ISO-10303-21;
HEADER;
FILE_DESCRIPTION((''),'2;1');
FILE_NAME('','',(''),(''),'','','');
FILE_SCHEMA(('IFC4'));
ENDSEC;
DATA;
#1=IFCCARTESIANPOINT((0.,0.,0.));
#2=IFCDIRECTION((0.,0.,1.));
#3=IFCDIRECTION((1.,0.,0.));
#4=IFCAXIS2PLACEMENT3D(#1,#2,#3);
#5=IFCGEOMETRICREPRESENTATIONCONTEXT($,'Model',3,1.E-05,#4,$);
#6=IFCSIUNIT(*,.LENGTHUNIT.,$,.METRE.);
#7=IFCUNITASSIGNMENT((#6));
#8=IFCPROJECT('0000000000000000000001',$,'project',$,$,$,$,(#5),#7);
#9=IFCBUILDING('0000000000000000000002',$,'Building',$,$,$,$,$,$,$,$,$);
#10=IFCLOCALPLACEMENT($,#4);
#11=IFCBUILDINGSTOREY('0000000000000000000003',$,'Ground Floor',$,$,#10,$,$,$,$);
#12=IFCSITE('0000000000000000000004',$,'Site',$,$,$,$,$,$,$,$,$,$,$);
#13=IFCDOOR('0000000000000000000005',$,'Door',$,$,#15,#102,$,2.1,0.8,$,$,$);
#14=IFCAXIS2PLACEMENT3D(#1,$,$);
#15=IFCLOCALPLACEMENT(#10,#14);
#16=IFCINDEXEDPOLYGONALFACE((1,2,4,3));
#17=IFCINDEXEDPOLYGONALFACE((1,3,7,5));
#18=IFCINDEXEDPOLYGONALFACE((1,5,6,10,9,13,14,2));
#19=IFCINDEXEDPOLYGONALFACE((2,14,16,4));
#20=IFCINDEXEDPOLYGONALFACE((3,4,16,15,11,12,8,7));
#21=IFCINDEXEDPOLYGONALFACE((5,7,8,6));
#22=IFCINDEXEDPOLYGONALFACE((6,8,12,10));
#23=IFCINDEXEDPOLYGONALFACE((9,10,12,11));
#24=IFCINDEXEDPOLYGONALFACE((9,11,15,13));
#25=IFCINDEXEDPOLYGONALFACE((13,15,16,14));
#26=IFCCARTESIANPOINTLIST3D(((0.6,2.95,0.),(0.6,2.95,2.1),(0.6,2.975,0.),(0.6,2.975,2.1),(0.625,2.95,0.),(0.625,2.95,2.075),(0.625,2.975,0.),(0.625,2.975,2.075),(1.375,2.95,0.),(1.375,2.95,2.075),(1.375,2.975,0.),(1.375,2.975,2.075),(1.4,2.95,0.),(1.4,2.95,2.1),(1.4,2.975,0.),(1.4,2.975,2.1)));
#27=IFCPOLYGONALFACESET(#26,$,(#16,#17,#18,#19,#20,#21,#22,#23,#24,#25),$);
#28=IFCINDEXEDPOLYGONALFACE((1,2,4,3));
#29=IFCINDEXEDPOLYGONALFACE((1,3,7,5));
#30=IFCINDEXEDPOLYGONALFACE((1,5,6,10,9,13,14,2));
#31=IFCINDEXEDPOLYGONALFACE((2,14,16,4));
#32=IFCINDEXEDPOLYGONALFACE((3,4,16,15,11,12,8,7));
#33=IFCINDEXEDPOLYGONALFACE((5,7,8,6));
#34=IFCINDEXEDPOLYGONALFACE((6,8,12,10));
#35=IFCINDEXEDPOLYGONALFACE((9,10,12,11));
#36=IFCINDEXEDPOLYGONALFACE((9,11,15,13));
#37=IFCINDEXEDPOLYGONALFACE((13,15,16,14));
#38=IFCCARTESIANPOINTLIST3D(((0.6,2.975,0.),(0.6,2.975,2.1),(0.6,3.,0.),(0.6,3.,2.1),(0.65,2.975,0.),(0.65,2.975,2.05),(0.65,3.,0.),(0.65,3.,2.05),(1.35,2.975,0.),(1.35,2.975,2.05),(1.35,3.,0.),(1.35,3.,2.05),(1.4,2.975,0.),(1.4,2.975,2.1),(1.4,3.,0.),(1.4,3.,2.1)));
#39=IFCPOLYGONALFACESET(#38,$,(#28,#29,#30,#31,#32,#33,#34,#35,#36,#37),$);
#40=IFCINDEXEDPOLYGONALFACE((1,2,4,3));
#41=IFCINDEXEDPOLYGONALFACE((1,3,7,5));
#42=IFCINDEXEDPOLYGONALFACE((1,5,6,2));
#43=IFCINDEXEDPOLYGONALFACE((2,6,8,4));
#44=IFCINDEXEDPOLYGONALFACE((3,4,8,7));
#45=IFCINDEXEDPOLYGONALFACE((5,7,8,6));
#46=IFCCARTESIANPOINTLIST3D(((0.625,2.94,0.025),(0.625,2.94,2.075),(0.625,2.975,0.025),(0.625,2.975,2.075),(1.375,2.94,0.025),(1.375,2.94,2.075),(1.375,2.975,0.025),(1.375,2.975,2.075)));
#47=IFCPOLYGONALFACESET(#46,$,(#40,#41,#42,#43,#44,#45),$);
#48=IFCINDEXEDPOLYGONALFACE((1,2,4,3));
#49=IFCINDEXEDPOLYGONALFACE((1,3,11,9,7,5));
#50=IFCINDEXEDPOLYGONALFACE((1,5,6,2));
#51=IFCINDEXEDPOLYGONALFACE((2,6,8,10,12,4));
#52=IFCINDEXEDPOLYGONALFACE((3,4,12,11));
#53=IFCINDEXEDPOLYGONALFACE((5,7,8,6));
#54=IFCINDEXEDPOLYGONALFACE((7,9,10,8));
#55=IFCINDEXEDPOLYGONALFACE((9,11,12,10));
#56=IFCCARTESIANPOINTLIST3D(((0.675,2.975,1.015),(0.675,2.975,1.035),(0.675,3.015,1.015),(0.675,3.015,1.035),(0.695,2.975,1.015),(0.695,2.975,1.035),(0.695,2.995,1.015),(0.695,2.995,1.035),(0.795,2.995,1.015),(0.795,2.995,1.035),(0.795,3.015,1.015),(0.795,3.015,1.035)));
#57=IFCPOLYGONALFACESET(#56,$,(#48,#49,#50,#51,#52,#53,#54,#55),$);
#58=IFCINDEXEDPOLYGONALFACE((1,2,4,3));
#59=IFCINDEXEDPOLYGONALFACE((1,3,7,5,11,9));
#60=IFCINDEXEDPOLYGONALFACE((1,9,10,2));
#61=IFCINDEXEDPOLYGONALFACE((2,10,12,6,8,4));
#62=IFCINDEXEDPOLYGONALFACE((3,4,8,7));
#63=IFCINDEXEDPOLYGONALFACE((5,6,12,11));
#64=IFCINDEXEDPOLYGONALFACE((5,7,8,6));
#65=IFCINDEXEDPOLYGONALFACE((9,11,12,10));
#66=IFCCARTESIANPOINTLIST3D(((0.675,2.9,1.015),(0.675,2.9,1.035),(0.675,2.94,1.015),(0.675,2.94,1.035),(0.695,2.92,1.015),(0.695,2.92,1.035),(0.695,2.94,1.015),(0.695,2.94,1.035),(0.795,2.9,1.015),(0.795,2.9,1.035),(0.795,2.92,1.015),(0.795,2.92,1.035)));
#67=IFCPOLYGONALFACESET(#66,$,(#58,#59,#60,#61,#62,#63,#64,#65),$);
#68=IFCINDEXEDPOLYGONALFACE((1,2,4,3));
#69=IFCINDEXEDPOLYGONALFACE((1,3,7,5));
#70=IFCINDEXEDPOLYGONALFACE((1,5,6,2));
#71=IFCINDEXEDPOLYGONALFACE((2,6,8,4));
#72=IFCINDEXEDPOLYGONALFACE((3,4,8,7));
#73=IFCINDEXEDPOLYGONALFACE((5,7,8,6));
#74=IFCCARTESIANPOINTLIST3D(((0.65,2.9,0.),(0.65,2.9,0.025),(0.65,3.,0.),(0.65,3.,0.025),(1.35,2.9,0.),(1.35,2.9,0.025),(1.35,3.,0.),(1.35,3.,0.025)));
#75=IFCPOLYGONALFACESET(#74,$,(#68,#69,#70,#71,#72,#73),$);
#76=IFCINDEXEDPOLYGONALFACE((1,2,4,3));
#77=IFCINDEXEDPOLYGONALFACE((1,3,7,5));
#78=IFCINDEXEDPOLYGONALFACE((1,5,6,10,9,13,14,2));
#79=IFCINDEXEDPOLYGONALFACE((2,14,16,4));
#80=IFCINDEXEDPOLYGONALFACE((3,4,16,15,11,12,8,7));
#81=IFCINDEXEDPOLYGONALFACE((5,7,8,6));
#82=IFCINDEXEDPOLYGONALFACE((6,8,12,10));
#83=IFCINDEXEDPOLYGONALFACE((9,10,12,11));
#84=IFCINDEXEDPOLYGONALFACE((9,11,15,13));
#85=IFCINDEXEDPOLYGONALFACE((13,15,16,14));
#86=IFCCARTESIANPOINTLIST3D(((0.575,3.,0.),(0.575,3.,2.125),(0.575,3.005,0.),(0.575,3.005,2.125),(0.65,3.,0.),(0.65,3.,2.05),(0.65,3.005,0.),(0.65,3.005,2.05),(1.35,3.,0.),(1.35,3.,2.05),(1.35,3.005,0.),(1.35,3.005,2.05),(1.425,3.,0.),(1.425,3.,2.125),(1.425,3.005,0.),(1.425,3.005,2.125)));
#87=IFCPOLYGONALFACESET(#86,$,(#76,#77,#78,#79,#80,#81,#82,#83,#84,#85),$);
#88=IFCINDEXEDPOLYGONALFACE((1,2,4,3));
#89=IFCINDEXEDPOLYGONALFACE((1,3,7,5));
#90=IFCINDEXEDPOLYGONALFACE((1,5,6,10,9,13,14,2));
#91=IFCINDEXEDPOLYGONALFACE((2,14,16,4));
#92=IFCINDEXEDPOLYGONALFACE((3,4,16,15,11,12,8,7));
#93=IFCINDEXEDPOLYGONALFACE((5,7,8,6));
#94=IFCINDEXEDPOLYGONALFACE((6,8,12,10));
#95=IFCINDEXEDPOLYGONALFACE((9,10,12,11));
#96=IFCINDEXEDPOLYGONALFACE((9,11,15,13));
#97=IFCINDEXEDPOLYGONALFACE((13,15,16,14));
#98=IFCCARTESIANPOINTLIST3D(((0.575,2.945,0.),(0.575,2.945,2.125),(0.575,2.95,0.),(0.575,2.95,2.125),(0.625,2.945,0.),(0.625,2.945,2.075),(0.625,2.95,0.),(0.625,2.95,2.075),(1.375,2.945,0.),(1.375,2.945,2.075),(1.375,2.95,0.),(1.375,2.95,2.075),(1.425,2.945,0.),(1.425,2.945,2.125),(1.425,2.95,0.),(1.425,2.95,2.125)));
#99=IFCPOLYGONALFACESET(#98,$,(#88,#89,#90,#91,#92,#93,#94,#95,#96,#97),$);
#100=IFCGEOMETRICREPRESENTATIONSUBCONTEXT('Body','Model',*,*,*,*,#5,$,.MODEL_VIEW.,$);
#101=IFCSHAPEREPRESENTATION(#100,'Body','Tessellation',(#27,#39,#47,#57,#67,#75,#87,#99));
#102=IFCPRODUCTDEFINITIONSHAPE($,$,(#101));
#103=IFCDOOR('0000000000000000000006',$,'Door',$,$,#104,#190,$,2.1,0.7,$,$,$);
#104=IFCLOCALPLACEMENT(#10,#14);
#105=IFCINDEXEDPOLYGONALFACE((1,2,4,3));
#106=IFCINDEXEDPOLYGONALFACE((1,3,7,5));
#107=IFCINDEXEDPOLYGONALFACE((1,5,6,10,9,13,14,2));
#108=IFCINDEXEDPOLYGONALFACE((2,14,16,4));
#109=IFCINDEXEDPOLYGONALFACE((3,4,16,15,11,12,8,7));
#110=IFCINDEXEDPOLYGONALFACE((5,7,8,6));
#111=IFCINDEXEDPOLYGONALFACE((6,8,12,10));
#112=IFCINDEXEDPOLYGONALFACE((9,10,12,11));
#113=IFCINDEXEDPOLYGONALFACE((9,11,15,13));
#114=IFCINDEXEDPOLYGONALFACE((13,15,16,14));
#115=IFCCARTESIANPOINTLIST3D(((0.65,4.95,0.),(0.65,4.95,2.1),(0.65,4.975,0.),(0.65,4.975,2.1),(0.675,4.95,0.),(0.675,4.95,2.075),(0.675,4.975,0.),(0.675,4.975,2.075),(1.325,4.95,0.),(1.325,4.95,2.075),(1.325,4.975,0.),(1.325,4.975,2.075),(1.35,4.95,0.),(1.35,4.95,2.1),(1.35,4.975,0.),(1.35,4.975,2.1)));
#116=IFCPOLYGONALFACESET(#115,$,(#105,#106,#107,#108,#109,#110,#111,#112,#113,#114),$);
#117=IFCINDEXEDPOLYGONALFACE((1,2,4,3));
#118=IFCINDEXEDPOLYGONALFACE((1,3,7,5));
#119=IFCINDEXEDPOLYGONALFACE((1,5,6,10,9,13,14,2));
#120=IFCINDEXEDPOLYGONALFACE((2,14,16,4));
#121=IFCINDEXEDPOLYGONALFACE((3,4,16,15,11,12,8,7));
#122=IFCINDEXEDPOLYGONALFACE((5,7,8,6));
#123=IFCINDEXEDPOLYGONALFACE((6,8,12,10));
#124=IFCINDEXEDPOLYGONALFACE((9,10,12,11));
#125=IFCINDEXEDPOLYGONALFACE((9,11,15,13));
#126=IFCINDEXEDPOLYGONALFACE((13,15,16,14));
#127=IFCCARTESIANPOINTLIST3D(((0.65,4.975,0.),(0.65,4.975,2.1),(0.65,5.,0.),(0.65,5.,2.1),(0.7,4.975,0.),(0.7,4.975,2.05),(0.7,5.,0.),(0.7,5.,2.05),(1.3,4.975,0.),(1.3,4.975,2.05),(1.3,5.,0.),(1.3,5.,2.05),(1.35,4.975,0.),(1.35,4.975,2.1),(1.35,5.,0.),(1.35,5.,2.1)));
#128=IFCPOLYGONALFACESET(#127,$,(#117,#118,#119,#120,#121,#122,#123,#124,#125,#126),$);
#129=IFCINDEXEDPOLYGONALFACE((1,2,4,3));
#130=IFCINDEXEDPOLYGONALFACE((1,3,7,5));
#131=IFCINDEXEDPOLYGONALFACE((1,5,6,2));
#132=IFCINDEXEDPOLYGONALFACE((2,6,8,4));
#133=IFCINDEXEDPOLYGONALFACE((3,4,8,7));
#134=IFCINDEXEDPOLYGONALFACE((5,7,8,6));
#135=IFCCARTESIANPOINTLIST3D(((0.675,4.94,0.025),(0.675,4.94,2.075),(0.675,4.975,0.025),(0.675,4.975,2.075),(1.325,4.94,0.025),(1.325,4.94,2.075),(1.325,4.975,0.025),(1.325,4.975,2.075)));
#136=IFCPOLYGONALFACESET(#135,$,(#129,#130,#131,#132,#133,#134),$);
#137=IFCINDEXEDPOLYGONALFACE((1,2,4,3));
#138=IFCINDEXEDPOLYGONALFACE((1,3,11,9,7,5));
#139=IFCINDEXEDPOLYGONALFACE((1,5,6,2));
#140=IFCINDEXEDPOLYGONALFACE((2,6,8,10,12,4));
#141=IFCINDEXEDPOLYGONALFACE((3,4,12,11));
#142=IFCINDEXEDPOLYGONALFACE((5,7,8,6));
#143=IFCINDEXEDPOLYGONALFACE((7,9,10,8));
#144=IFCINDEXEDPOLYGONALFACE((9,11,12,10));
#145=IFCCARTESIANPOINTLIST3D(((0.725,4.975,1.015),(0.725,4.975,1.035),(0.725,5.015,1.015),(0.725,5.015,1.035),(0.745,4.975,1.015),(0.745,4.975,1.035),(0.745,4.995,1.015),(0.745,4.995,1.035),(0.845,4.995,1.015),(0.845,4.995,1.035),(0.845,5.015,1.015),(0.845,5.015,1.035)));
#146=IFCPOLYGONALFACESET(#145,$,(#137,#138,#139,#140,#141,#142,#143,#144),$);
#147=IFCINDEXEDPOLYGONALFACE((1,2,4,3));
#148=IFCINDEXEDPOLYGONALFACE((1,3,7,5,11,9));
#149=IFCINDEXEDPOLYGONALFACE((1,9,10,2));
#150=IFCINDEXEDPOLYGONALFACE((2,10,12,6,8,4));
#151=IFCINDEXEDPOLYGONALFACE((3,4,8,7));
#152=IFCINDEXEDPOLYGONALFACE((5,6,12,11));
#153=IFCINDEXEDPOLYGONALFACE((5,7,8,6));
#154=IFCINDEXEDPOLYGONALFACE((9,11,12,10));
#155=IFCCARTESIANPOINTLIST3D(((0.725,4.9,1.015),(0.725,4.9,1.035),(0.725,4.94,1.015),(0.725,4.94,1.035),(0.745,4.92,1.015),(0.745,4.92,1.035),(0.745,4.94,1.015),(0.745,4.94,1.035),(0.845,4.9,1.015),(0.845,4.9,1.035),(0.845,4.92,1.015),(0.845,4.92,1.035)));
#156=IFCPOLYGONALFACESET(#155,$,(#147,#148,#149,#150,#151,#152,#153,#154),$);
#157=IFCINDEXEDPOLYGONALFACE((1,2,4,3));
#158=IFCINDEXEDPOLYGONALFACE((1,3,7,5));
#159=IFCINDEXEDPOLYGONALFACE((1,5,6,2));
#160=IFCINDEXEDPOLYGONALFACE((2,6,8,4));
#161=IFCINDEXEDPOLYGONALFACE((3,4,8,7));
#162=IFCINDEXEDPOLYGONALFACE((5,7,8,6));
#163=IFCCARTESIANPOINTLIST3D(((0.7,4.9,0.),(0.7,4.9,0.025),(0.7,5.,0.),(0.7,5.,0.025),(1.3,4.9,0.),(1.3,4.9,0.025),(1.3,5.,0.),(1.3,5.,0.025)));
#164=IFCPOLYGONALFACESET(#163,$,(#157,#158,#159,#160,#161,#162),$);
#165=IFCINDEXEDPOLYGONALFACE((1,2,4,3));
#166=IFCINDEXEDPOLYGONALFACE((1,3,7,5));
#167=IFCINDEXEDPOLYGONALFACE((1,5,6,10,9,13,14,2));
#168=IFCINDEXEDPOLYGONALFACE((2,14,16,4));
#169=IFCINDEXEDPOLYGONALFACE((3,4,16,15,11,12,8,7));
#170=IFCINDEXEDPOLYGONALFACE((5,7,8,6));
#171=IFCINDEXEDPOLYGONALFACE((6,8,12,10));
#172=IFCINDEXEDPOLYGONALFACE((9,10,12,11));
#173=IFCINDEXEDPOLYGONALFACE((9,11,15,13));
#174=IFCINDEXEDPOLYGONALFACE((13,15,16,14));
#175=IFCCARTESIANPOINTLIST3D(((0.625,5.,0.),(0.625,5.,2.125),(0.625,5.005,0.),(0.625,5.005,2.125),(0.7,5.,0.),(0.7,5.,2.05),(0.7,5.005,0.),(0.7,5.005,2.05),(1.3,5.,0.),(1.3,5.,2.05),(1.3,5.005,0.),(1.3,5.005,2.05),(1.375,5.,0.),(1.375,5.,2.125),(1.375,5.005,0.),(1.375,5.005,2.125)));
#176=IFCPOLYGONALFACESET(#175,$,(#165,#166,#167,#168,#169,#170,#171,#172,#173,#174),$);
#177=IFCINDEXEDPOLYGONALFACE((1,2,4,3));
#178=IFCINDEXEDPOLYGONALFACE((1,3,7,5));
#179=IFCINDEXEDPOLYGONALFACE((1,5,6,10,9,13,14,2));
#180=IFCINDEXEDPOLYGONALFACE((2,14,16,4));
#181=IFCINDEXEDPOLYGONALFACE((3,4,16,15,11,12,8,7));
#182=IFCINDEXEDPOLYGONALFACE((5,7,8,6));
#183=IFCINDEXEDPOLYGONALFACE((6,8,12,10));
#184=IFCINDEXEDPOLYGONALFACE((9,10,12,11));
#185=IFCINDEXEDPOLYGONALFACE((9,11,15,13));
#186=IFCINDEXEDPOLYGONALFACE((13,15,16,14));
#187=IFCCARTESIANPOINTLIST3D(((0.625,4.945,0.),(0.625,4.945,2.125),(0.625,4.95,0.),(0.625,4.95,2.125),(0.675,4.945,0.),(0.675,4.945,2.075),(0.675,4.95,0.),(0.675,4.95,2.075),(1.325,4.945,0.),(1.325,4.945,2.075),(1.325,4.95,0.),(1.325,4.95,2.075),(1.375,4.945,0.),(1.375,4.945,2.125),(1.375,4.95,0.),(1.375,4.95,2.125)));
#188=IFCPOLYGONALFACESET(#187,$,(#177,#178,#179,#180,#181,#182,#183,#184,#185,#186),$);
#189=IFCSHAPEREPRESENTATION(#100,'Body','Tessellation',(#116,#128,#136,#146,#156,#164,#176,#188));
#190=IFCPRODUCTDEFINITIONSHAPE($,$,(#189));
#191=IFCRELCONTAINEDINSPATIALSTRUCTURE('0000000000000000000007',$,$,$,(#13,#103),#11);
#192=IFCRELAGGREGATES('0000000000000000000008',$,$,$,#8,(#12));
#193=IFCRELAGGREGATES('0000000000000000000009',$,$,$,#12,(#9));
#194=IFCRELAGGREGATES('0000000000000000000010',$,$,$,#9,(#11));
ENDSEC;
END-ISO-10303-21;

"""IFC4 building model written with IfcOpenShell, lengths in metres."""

from ifc_helpers import new_model, si_unit, frame, origin_with_axes, place, context, subcontext, project, spatial, line, indexed_curve, outline, extrude, element, save


model = new_model("IFC4")

# Units and contexts
model_context = context("Model", 3, precision=1e-05, world=origin_with_axes())
body_context = subcontext(model_context, "Body", "Model", "MODEL_VIEW")
ifc_project = project(units=[si_unit("LENGTHUNIT", "METRE")], contexts=[model_context])

# Site, building, storey
site = spatial("IfcSite", under=ifc_project, Name="Site")
building = spatial("IfcBuilding", under=site, Name="Building")
storey_placement = place(None, origin_with_axes())
storey = spatial("IfcBuildingStorey", under=building, at=storey_placement, Name="Ground Floor")

# Doors
door_1_placement = place(storey_placement, frame((1.4, 3.0, 0.0), z_axis=(0.0, 0.0, 1.0), x_axis=(-1.0, 0.0, 0.0)))
element("IfcDoor", 1, at=door_1_placement, inside=storey, Name="Door", OverallHeight=2.1, OverallWidth=0.8, context=body_context, shape_type="SweptSolid", body=[
    extrude(outline(indexed_curve([(0.0, 0.0), (0.0, 2.1), (0.8, 2.1), (0.8, 0.0), (0.775, 0.0), (0.775, 2.075), (0.025, 2.075), (0.025, 0.0)], segments=[line(1, 2, 3, 4, 5, 6, 7, 8, 1)])), frame((0.0, 0.025, 0.0), z_axis=(0.0, -1.0, 0.0), x_axis=(1.0, 0.0, 0.0)), (0.0, 0.0, -1.0), 0.025),
    extrude(outline(indexed_curve([(0.0, 0.0), (0.0, 2.1), (0.8, 2.1), (0.8, 0.0), (0.75, 0.0), (0.75, 2.05), (0.05, 2.05), (0.05, 0.0)], segments=[line(1, 2, 3, 4, 5, 6, 7, 8, 1)])), frame((0.0, 0.0, 0.0), z_axis=(0.0, -1.0, 0.0), x_axis=(1.0, 0.0, 0.0)), (0.0, 0.0, -1.0), 0.025),
    extrude(outline(indexed_curve([(0.0, 0.0), (0.75, 0.0), (0.75, 0.035), (0.0, 0.035)], segments=[line(1, 2, 3, 4, 1)])), frame((0.025, 0.025, 0.025), z_axis=(0.0, 0.0, 1.0), x_axis=(1.0, 0.0, 0.0)), (0.0, 0.0, 1.0), 2.05),
    extrude(outline(indexed_curve([(0.0, 0.0), (0.0, -0.04), (-0.12, -0.04), (-0.12, -0.02), (-0.02, -0.02), (-0.02, 0.0)], segments=[line(1, 2, 3, 4, 5, 6, 1)])), frame((0.725, 0.025, 1.015), z_axis=(0.0, 0.0, 1.0), x_axis=(1.0, 0.0, 0.0)), (0.0, 0.0, 1.0), 0.02),
    extrude(outline(indexed_curve([(0.0, 0.0), (0.0, 0.04), (-0.12, 0.04), (-0.12, 0.02), (-0.02, 0.02), (-0.02, 0.0)], segments=[line(1, 2, 3, 4, 5, 6, 1)])), frame((0.725, 0.06, 1.015), z_axis=(0.0, 0.0, 1.0), x_axis=(1.0, 0.0, 0.0)), (0.0, 0.0, 1.0), 0.02),
    extrude(outline(indexed_curve([(0.0, 0.0), (0.7, 0.0), (0.7, 0.1), (0.0, 0.1)], segments=[line(1, 2, 3, 4, 1)])), frame((0.05, 0.0, 0.0), z_axis=(0.0, 0.0, 1.0), x_axis=(1.0, 0.0, 0.0)), (0.0, 0.0, 1.0), 0.025),
    extrude(outline(indexed_curve([(0.0, 0.0), (0.0, 2.125), (0.85, 2.125), (0.85, 0.0), (0.775, 0.0), (0.775, 2.05), (0.075, 2.05), (0.075, 0.0)], segments=[line(1, 2, 3, 4, 5, 6, 7, 8, 1)])), frame((-0.025, -0.005, 0.0), z_axis=(0.0, -1.0, 0.0), x_axis=(1.0, 0.0, 0.0)), (0.0, 0.0, -1.0), 0.005),
    extrude(outline(indexed_curve([(0.0, 0.0), (0.0, 2.125), (0.85, 2.125), (0.85, 0.0), (0.8, 0.0), (0.8, 2.075), (0.05, 2.075), (0.05, 0.0)], segments=[line(1, 2, 3, 4, 5, 6, 7, 8, 1)])), frame((-0.025, 0.05, 0.0), z_axis=(0.0, -1.0, 0.0), x_axis=(1.0, 0.0, 0.0)), (0.0, 0.0, -1.0), 0.005),
])
door_2_placement = place(storey_placement, frame((1.35, 5.0, 0.0), z_axis=(0.0, 0.0, 1.0), x_axis=(-1.0, 0.0, 0.0)))
element("IfcDoor", 2, at=door_2_placement, inside=storey, Name="Door", OverallHeight=2.1, OverallWidth=0.7, context=body_context, shape_type="SweptSolid", body=[
    extrude(outline(indexed_curve([(0.0, 0.0), (0.0, 2.1), (0.7, 2.1), (0.7, 0.0), (0.675, 0.0), (0.675, 2.075), (0.025, 2.075), (0.025, 0.0)], segments=[line(1, 2, 3, 4, 5, 6, 7, 8, 1)])), frame((0.0, 0.025, 0.0), z_axis=(0.0, -1.0, 0.0), x_axis=(1.0, 0.0, 0.0)), (0.0, 0.0, -1.0), 0.025),
    extrude(outline(indexed_curve([(0.0, 0.0), (0.0, 2.1), (0.7, 2.1), (0.7, 0.0), (0.65, 0.0), (0.65, 2.05), (0.05, 2.05), (0.05, 0.0)], segments=[line(1, 2, 3, 4, 5, 6, 7, 8, 1)])), frame((0.0, 0.0, 0.0), z_axis=(0.0, -1.0, 0.0), x_axis=(1.0, 0.0, 0.0)), (0.0, 0.0, -1.0), 0.025),
    extrude(outline(indexed_curve([(0.0, 0.0), (0.65, 0.0), (0.65, 0.035), (0.0, 0.035)], segments=[line(1, 2, 3, 4, 1)])), frame((0.025, 0.025, 0.025), z_axis=(0.0, 0.0, 1.0), x_axis=(1.0, 0.0, 0.0)), (0.0, 0.0, 1.0), 2.05),
    extrude(outline(indexed_curve([(0.0, 0.0), (0.0, -0.04), (-0.12, -0.04), (-0.12, -0.02), (-0.02, -0.02), (-0.02, 0.0)], segments=[line(1, 2, 3, 4, 5, 6, 1)])), frame((0.625, 0.025, 1.015), z_axis=(0.0, 0.0, 1.0), x_axis=(1.0, 0.0, 0.0)), (0.0, 0.0, 1.0), 0.02),
    extrude(outline(indexed_curve([(0.0, 0.0), (0.0, 0.04), (-0.12, 0.04), (-0.12, 0.02), (-0.02, 0.02), (-0.02, 0.0)], segments=[line(1, 2, 3, 4, 5, 6, 1)])), frame((0.625, 0.06, 1.015), z_axis=(0.0, 0.0, 1.0), x_axis=(1.0, 0.0, 0.0)), (0.0, 0.0, 1.0), 0.02),
    extrude(outline(indexed_curve([(0.0, 0.0), (0.6, 0.0), (0.6, 0.1), (0.0, 0.1)], segments=[line(1, 2, 3, 4, 1)])), frame((0.05, 0.0, 0.0), z_axis=(0.0, 0.0, 1.0), x_axis=(1.0, 0.0, 0.0)), (0.0, 0.0, 1.0), 0.025),
    extrude(outline(indexed_curve([(0.0, 0.0), (0.0, 2.125), (0.75, 2.125), (0.75, 0.0), (0.675, 0.0), (0.675, 2.05), (0.075, 2.05), (0.075, 0.0)], segments=[line(1, 2, 3, 4, 5, 6, 7, 8, 1)])), frame((-0.025, -0.005, 0.0), z_axis=(0.0, -1.0, 0.0), x_axis=(1.0, 0.0, 0.0)), (0.0, 0.0, -1.0), 0.005),
    extrude(outline(indexed_curve([(0.0, 0.0), (0.0, 2.125), (0.75, 2.125), (0.75, 0.0), (0.7, 0.0), (0.7, 2.075), (0.05, 2.075), (0.05, 0.0)], segments=[line(1, 2, 3, 4, 5, 6, 7, 8, 1)])), frame((-0.025, 0.05, 0.0), z_axis=(0.0, -1.0, 0.0), x_axis=(1.0, 0.0, 0.0)), (0.0, 0.0, -1.0), 0.005),
])

save(model, "model.ifc")
